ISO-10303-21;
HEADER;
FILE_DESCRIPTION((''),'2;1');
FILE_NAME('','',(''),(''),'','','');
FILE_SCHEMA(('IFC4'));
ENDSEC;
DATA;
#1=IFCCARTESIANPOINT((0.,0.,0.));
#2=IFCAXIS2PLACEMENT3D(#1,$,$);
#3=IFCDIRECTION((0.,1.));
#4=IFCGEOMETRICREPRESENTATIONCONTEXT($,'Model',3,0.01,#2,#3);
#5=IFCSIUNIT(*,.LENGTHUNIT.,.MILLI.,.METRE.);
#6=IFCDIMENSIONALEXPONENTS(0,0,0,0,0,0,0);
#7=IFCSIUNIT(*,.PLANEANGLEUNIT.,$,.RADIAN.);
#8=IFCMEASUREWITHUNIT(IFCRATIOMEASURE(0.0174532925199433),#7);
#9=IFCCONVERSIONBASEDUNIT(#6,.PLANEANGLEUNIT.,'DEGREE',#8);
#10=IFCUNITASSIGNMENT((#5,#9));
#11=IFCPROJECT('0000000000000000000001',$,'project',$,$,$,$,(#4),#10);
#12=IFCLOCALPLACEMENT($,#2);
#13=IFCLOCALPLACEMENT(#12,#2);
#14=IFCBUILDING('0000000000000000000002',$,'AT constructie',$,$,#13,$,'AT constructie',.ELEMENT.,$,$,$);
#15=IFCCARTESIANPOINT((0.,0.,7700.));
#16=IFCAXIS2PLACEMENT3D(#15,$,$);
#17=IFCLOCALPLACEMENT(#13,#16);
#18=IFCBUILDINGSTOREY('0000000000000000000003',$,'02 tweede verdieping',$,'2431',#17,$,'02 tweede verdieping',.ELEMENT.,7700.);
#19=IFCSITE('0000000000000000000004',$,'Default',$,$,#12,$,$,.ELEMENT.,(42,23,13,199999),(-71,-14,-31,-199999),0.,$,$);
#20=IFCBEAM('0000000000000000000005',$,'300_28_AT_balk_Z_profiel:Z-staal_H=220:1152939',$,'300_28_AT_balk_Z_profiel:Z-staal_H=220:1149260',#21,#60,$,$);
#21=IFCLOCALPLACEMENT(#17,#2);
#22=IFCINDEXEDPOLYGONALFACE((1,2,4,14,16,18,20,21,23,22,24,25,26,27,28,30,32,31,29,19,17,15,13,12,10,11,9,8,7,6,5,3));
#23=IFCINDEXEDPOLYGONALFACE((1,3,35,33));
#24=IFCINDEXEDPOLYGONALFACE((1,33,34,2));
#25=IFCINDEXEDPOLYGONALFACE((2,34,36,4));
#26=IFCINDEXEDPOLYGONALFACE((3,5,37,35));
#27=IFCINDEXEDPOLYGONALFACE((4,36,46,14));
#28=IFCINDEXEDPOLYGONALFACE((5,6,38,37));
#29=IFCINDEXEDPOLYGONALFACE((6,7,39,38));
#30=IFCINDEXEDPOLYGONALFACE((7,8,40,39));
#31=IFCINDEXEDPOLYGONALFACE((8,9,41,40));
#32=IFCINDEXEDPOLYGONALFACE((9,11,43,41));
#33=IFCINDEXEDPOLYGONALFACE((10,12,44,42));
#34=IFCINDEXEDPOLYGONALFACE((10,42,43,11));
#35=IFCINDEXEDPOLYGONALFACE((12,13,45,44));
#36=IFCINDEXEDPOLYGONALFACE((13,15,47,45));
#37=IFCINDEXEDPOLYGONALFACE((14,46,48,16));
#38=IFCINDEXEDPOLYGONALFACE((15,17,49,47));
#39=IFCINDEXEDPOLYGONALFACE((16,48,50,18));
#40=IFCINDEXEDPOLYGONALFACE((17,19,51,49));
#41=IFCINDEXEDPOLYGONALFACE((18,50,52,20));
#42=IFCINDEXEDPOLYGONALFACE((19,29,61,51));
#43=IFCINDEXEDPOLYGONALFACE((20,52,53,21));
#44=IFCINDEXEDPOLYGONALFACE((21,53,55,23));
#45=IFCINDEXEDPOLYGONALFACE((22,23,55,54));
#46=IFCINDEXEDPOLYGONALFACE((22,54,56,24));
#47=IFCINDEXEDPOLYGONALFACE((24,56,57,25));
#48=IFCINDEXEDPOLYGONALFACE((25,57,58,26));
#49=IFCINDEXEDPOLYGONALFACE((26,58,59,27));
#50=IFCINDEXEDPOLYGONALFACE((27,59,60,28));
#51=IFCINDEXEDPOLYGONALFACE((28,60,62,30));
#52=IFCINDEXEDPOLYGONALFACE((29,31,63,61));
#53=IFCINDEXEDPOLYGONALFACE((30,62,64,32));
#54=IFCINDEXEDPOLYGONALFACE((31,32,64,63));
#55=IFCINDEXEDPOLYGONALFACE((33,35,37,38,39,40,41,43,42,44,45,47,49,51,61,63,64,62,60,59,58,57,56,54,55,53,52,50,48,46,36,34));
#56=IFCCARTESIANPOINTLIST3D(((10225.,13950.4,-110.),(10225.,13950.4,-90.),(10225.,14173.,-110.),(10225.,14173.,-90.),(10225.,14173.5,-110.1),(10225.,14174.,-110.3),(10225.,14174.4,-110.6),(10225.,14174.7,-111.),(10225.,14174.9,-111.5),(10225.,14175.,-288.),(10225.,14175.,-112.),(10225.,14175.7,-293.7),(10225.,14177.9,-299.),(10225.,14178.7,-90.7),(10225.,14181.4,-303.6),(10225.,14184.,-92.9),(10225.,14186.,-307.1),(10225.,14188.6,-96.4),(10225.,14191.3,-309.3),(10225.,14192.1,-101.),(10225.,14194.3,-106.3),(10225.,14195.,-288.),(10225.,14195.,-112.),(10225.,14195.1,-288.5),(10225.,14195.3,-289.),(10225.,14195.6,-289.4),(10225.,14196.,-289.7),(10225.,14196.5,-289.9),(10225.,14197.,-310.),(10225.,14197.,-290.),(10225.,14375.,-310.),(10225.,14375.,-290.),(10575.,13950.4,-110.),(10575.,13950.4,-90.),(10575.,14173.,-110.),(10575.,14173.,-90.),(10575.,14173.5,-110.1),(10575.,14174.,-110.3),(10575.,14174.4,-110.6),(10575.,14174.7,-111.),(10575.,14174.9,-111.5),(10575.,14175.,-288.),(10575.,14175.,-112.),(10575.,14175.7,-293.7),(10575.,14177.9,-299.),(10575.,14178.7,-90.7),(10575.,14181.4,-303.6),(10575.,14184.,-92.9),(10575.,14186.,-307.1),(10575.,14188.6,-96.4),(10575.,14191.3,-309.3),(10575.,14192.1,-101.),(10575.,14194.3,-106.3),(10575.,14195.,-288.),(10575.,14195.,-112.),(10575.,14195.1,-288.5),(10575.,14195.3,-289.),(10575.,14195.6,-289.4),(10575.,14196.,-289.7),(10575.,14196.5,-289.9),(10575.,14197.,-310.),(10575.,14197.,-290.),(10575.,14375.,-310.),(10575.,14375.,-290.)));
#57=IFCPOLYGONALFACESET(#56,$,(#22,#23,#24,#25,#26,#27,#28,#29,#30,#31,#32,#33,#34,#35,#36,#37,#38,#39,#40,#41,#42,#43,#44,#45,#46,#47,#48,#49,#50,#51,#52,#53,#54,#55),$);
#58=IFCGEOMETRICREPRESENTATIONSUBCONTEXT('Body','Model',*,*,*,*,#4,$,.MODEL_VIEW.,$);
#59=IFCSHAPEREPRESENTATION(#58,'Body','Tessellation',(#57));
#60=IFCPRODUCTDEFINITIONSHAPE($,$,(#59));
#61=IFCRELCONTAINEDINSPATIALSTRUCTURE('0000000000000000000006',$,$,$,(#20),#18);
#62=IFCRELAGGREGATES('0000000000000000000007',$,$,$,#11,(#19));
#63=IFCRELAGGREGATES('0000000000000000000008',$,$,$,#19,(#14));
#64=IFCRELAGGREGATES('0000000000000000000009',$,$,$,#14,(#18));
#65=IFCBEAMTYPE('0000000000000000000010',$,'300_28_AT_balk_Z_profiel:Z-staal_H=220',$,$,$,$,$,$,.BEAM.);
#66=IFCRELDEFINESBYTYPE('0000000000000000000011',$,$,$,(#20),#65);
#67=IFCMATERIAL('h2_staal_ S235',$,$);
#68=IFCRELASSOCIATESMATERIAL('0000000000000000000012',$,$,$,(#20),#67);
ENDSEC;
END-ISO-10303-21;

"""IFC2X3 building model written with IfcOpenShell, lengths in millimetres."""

from ifc_helpers import new_model, entity, si_unit, converted_unit, direction, frame, frame_2d, origin, place, context, subcontext, project, spatial, polyline, circle_curve, parameter, trimmed, segment, composite_curve, outline, extrude, material, type_object, element, save


model = new_model("IFC2X3")

# Units and contexts
model_context = context("Model", 3, precision=0.01, world=origin(), true_north=direction((0.0, 1.0)))
body_context = subcontext(model_context, "Body", "Model", "MODEL_VIEW")
ifc_project = project(units=[si_unit("LENGTHUNIT", "METRE", prefix="MILLI"), converted_unit("PLANEANGLEUNIT", "DEGREE", entity("IfcRatioMeasure", 0.0174532925199433), si_unit("PLANEANGLEUNIT", "RADIAN"), dimensions=[0, 0, 0, 0, 0, 0, 0])], contexts=[model_context])

# Site, building, storey
site_placement = place(None, origin())
site = spatial("IfcSite", under=ifc_project, at=site_placement, Name="Default", CompositionType="ELEMENT", RefLatitude=(42, 23, 13, 199999), RefLongitude=(-71, -14, -31, -199999), RefElevation=0.0)
building_placement = place(site_placement, origin())
building = spatial("IfcBuilding", under=site, at=building_placement, Name="AT constructie", LongName="AT constructie", CompositionType="ELEMENT")
storey_placement = place(building_placement, frame((0.0, 0.0, 7700.0)))
storey = spatial("IfcBuildingStorey", under=building, at=storey_placement, Name="02 tweede verdieping", ObjectType="2431", LongName="02 tweede verdieping", CompositionType="ELEMENT", Elevation=7700.0)

# Beam
ifc_material = material(Name="h2_staal_ S235")
beam_type = type_object("IfcBeamType", Name="300_28_AT_balk_Z_profiel:Z-staal_H=220", PredefinedType="BEAM")
beam_placement = place(storey_placement, frame((10575.0, 14175.0, -90.0), z_axis=(0.0, 0.0, 1.0), x_axis=(-1.0, 0.0, 0.0)))
element("IfcBeam", 1, at=beam_placement, inside=storey, type_object=beam_type, material=ifc_material, Name="300_28_AT_balk_Z_profiel:Z-staal_H=220:1152939", ObjectType="300_28_AT_balk_Z_profiel:Z-staal_H=220:1149260", context=body_context, shape_type="SweptSolid", body=[
    extrude(outline(composite_curve([segment(polyline([(90.0, -197.4), (110.0, -197.4)]), True, "CONTINUOUS"), segment(polyline([(110.0, -197.4), (110.0, -19.4)]), True, "CONTINUOUS"), segment(trimmed(circle_curve(frame_2d((88.0, -19.4), x_axis=(1.0, 0.0)), 22.0), [parameter(0.0)], [parameter(90.0)], True, "PARAMETER"), True, "CONTINUOUS"), segment(polyline([(88.0, 2.6), (-88.0, 2.6)]), True, "CONTINUOUS"), segment(trimmed(circle_curve(frame_2d((-88.0, 4.6), x_axis=(0.0, -1.0)), 2.0), [parameter(270.0)], [parameter(0.0)], True, "PARAMETER"), False, "CONTINUOUS"), segment(polyline([(-90.0, 4.6), (-90.0, 227.2)]), True, "CONTINUOUS"), segment(polyline([(-90.0, 227.2), (-110.0, 227.2)]), True, "CONTINUOUS"), segment(polyline([(-110.0, 227.2), (-110.0, 4.6)]), True, "CONTINUOUS"), segment(trimmed(circle_curve(frame_2d((-88.0, 4.6), x_axis=(-1.0, 0.0)), 22.0), [parameter(0.0)], [parameter(90.0)], True, "PARAMETER"), True, "CONTINUOUS"), segment(polyline([(-88.0, -17.4), (88.0, -17.4)]), True, "CONTINUOUS"), segment(trimmed(circle_curve(frame_2d((88.0, -19.4), x_axis=(0.0, 1.0)), 2.0), [parameter(270.0)], [parameter(0.0)], True, "PARAMETER"), False, "CONTINUOUS"), segment(polyline([(90.0, -19.4), (90.0, -197.4)]), True, "CONTINUOUS")], self_intersect=False)), frame((0.0, -2.6, -110.0), z_axis=(1.0, 0.0, 0.0), x_axis=(0.0, 0.0, -1.0)), (0.0, 0.0, 1.0), 350.0),
])

save(model, "model.ifc")
